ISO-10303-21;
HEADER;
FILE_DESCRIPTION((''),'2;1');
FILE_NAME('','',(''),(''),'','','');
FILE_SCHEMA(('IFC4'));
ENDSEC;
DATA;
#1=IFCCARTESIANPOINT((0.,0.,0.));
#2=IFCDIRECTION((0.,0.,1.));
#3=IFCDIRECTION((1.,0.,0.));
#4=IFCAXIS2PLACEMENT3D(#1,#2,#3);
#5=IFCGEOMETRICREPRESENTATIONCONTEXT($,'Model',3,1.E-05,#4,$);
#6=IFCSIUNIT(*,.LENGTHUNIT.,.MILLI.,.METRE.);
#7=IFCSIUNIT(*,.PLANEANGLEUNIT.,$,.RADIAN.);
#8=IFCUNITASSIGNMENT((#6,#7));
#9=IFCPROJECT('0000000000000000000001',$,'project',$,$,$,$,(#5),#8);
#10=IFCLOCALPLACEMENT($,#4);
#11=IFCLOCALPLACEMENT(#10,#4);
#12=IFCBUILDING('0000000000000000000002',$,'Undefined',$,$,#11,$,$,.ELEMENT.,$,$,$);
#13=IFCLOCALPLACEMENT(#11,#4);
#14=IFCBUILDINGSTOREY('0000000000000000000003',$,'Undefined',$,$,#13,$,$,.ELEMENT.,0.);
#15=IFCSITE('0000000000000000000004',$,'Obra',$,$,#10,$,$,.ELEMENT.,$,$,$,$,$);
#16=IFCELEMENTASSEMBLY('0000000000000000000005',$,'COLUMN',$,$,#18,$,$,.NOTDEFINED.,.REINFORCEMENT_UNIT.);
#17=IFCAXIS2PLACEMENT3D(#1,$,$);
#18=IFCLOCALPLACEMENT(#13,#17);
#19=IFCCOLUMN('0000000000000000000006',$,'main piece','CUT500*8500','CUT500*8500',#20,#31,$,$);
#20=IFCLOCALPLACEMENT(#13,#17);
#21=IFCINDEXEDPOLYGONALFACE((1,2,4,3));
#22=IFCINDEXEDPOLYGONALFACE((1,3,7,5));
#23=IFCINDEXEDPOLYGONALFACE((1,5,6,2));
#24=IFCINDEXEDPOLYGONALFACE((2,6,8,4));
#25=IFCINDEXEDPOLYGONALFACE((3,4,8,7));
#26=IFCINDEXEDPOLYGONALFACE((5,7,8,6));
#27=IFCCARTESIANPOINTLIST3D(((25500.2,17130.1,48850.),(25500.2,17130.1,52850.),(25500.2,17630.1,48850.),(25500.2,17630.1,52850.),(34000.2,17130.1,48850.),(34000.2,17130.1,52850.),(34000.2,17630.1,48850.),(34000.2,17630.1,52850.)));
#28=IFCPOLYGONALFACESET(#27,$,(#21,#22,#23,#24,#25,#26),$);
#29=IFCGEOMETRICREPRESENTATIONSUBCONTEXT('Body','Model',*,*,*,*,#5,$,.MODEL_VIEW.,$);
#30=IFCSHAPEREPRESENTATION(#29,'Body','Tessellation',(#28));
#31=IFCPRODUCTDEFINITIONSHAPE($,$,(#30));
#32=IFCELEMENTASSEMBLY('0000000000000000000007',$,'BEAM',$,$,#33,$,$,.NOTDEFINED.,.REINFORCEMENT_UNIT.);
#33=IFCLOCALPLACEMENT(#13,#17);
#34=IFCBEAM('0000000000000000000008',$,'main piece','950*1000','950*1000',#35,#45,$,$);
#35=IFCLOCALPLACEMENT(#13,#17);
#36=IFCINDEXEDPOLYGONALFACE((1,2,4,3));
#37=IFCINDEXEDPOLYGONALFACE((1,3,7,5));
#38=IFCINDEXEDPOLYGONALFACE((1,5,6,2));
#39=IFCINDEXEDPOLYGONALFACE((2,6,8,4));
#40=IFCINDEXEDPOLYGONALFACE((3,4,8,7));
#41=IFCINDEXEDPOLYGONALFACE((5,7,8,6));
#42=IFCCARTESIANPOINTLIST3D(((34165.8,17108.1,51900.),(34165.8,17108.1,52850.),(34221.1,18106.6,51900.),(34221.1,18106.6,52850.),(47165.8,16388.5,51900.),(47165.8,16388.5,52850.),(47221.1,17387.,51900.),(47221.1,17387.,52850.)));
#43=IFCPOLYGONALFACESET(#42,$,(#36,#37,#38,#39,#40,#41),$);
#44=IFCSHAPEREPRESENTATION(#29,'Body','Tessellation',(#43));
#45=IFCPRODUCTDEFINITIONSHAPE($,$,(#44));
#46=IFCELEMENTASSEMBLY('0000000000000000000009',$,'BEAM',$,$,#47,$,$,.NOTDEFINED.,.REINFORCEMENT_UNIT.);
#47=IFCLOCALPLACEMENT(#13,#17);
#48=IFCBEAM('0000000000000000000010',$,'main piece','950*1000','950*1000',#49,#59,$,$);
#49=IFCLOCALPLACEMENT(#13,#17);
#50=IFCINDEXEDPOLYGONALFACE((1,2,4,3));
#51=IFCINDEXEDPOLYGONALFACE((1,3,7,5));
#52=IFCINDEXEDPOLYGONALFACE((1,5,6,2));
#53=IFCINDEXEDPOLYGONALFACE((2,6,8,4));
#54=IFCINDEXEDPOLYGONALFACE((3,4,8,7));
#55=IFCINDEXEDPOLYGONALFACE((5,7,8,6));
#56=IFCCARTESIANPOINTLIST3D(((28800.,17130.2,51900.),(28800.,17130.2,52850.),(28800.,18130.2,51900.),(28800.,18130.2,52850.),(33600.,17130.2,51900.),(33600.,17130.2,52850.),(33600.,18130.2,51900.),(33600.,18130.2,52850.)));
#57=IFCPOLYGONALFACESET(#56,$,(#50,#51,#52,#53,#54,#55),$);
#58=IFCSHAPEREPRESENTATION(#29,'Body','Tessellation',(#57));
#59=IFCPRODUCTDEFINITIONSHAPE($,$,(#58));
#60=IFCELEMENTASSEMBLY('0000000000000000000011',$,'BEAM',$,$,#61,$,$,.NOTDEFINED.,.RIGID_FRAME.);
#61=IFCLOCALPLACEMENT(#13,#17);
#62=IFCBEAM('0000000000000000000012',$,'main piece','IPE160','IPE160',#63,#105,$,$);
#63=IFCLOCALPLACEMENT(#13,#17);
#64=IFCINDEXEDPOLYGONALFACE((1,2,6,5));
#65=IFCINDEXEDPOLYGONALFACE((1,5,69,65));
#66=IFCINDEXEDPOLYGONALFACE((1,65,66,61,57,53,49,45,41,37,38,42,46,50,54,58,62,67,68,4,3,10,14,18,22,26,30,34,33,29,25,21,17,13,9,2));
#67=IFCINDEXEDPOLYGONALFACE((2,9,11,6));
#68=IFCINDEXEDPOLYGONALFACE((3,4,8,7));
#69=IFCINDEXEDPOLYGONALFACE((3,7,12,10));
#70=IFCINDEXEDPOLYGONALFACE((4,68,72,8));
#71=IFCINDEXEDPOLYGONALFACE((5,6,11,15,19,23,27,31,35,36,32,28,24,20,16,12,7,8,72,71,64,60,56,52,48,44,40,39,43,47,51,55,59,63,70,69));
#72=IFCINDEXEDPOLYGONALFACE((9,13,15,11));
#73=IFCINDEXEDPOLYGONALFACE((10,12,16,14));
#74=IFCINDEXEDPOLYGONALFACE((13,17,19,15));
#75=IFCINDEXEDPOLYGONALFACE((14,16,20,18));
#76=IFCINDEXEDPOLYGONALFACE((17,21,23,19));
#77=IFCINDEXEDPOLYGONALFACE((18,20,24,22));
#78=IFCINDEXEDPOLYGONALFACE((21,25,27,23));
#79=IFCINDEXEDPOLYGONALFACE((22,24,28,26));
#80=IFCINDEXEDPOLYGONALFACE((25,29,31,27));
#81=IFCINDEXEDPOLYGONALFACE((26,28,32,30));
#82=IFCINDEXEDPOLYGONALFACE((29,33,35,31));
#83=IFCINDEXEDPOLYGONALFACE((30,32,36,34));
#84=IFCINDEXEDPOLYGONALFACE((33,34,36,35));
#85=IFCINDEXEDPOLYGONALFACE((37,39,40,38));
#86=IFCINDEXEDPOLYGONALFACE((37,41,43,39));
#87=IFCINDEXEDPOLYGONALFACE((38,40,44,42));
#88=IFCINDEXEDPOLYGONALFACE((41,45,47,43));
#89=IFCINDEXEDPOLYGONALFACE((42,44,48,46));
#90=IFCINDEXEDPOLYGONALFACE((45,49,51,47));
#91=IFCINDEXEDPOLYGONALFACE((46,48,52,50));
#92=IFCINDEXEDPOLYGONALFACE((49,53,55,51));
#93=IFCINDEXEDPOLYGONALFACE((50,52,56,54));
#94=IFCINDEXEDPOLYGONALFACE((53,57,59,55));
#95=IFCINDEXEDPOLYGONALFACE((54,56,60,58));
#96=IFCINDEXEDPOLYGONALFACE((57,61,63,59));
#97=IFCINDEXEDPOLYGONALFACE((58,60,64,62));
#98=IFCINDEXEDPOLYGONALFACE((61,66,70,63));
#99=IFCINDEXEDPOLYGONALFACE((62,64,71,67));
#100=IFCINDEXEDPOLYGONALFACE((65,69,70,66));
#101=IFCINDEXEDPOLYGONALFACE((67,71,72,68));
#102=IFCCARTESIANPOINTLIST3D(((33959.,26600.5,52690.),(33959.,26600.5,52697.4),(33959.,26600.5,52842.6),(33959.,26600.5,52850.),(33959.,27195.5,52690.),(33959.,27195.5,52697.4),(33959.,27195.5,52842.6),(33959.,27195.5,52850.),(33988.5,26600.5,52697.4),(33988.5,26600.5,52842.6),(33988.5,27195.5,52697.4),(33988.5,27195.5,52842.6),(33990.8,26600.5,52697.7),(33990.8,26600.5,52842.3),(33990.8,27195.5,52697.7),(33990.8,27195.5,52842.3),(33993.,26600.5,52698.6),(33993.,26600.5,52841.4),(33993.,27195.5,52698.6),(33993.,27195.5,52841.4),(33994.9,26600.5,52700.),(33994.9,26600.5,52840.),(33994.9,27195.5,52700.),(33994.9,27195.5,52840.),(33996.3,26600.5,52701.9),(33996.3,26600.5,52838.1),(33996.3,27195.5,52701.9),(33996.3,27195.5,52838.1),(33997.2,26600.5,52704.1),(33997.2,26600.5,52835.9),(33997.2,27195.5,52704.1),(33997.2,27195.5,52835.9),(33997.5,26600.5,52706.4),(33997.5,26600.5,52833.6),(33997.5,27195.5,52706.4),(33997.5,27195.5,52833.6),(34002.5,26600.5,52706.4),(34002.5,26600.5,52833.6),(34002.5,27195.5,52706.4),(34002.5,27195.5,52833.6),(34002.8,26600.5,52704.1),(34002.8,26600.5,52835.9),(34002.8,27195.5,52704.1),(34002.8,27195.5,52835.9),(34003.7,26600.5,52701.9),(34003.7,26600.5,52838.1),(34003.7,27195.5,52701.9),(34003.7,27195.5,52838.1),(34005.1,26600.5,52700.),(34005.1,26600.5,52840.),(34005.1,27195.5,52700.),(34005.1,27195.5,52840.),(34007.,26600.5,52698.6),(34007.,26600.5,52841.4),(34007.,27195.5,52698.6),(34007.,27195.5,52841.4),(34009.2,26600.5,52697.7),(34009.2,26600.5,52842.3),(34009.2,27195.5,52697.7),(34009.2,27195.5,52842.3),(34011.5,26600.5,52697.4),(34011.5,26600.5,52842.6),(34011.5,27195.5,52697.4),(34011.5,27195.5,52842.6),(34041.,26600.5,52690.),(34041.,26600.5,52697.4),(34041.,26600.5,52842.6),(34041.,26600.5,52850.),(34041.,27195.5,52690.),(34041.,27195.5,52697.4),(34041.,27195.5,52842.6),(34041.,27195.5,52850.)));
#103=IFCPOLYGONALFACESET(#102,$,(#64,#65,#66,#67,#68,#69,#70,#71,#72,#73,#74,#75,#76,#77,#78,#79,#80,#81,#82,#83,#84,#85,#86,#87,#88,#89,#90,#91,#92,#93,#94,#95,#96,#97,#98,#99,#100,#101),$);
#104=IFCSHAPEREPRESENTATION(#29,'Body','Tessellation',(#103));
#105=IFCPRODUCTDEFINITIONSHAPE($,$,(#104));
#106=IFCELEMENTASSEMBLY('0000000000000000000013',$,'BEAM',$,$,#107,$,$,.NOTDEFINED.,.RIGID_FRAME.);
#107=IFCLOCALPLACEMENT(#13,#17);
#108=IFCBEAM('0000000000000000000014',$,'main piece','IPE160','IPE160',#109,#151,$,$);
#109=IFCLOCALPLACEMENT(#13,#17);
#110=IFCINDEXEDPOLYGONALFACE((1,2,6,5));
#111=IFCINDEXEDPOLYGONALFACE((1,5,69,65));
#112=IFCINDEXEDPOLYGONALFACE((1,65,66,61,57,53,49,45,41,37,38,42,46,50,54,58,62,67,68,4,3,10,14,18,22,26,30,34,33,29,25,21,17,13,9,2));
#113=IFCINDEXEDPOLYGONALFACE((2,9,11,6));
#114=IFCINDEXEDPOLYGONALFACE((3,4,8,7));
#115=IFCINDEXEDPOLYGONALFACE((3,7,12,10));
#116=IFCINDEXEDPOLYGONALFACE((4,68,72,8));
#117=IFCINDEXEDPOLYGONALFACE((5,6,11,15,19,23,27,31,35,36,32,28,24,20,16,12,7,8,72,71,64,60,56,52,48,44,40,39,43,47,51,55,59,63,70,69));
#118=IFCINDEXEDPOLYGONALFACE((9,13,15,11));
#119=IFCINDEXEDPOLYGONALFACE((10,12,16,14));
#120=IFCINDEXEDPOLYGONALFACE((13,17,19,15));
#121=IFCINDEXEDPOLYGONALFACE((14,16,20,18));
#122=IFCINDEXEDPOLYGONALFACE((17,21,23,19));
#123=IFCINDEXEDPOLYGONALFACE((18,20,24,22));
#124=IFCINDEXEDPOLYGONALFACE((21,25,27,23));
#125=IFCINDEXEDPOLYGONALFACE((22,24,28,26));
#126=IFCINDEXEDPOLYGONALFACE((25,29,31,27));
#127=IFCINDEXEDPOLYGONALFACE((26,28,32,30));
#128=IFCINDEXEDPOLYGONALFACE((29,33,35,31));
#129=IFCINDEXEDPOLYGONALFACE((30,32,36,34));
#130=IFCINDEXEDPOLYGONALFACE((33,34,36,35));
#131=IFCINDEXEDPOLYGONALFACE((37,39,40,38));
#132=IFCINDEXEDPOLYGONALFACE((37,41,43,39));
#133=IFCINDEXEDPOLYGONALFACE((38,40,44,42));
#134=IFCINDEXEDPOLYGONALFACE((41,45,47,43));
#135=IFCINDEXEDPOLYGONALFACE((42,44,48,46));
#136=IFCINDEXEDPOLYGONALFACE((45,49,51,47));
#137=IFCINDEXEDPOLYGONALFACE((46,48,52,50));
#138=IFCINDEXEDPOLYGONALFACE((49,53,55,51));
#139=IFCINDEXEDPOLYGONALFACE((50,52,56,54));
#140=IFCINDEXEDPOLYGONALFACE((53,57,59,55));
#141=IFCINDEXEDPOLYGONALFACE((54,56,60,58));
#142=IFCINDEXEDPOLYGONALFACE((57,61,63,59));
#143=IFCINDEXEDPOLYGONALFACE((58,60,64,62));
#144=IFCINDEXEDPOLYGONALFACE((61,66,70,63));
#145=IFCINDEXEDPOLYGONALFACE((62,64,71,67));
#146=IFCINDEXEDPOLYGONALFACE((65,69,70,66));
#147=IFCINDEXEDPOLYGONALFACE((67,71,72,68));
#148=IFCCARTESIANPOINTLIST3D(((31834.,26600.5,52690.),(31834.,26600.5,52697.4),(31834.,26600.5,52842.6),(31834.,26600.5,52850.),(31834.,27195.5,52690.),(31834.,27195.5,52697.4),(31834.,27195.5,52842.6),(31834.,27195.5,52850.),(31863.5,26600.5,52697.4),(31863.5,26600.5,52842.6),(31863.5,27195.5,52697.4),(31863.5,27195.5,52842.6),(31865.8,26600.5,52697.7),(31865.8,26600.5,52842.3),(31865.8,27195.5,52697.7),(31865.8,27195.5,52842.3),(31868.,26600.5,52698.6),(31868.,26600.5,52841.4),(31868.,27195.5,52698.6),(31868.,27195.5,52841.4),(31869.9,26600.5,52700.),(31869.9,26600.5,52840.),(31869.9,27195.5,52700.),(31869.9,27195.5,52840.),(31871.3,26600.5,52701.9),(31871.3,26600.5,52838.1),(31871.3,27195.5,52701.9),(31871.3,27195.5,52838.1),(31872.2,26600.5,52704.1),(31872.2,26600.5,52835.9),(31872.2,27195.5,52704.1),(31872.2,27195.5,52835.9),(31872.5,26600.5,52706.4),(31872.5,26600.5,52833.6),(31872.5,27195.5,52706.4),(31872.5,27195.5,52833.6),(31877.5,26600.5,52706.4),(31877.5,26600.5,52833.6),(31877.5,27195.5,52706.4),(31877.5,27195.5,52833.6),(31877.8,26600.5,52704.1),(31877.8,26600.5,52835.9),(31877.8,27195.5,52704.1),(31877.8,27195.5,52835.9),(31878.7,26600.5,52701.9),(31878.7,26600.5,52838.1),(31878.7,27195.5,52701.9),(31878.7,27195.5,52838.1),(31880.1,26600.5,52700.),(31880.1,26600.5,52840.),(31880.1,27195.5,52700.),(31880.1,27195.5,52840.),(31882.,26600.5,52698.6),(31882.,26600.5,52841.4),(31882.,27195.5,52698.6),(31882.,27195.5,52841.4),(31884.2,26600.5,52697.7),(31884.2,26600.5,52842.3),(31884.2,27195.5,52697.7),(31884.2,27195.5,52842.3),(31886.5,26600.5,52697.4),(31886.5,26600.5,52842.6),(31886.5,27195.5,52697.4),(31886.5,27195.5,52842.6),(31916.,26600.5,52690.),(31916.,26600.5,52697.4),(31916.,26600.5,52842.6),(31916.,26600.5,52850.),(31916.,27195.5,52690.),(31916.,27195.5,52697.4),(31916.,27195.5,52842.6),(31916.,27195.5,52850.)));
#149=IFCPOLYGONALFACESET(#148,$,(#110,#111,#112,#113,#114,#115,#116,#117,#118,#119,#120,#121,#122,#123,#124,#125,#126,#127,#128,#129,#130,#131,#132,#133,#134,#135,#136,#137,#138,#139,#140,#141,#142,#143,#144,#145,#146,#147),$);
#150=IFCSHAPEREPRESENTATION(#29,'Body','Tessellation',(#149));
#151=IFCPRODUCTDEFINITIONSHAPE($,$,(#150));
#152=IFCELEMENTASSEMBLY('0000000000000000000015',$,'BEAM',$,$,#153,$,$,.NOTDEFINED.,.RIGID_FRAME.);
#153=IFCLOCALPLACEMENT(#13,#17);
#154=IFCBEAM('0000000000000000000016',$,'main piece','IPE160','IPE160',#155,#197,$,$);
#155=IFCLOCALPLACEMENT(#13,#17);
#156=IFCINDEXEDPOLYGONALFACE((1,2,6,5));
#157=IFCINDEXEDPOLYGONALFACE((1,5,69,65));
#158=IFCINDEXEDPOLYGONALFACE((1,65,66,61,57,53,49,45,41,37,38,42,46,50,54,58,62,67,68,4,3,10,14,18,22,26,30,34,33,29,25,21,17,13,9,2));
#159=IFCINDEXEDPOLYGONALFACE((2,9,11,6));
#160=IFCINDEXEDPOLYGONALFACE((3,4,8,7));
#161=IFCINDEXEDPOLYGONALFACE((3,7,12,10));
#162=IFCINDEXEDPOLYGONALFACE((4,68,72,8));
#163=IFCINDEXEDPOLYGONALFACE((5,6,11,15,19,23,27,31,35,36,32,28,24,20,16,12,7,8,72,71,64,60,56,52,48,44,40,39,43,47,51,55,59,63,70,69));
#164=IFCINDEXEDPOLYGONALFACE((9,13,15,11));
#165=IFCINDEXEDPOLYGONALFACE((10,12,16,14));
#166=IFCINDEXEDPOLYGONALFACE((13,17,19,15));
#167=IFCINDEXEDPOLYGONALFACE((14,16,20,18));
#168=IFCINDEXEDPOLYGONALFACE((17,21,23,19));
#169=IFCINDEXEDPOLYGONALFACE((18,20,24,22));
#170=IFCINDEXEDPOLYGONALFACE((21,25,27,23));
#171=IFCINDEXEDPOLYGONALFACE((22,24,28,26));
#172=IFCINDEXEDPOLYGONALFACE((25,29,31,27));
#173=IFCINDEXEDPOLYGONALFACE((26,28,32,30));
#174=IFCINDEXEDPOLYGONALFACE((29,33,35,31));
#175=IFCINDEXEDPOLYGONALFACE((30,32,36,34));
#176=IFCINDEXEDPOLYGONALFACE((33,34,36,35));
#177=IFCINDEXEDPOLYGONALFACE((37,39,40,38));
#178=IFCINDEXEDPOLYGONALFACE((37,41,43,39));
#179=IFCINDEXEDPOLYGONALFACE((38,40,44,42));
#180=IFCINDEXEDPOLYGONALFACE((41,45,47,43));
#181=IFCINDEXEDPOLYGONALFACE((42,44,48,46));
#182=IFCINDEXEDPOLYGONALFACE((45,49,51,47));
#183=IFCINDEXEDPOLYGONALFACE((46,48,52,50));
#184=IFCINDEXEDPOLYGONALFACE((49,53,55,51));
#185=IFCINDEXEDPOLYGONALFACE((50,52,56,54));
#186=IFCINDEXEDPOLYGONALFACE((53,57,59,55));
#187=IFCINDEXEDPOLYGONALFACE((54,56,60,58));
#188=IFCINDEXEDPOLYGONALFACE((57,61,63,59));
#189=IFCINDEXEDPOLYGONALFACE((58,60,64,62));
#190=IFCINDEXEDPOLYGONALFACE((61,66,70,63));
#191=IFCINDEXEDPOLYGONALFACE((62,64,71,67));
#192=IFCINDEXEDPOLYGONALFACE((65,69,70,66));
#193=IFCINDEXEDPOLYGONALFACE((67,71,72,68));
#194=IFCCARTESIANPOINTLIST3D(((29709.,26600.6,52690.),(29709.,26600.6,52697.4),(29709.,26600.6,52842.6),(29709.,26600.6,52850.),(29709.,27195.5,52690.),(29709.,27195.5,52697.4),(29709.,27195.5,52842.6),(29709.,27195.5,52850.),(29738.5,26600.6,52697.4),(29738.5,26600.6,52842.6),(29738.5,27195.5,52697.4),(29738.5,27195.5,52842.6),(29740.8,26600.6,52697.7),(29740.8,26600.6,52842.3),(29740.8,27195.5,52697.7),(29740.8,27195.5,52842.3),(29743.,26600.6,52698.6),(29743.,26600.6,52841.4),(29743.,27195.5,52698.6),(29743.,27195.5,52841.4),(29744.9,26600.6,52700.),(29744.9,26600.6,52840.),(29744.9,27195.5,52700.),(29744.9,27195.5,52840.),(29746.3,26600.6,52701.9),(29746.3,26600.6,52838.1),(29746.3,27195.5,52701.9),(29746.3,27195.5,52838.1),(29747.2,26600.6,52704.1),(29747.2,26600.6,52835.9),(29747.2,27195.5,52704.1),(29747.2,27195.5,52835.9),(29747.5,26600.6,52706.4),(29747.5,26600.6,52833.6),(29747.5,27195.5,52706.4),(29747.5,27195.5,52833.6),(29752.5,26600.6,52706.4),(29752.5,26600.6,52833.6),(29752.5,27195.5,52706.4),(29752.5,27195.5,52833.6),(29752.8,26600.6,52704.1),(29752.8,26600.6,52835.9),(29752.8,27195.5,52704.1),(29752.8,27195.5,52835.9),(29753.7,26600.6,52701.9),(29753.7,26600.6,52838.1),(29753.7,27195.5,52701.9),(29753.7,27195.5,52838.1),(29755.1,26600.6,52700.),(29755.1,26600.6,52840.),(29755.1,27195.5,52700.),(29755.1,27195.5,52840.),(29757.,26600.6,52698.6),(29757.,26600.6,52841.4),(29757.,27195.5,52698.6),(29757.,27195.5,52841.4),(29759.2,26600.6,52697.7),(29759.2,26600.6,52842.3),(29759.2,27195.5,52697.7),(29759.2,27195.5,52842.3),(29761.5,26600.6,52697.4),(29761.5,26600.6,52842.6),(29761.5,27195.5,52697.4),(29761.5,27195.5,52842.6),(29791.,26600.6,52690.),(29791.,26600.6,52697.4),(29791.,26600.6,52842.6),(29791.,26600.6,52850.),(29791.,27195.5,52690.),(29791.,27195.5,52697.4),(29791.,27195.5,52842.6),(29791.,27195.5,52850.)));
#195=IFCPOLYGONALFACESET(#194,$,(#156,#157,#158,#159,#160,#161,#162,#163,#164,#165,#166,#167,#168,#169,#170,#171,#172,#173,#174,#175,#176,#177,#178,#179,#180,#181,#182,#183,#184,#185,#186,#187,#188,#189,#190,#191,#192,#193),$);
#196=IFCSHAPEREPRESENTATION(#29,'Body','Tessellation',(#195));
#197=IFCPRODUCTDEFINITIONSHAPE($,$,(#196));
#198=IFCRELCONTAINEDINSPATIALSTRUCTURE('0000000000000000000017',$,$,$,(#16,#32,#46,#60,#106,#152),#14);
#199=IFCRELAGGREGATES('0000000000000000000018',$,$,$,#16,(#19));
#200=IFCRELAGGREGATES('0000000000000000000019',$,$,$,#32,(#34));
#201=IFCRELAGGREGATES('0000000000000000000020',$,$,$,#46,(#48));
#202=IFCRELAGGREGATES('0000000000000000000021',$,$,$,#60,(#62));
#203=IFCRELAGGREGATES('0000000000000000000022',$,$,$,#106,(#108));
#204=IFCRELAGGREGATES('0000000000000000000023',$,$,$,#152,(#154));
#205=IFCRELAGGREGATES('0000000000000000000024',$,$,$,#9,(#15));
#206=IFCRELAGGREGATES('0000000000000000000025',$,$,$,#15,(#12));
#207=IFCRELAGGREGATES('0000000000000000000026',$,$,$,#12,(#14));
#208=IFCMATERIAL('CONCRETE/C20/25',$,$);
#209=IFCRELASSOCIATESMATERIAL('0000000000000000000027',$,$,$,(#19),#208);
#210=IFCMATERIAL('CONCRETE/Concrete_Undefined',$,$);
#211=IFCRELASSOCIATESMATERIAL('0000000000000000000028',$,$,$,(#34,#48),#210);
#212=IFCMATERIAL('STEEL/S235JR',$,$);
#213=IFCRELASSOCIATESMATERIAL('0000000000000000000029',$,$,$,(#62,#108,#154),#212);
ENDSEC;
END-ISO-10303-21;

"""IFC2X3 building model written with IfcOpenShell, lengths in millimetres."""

from ifc_helpers import new_model, si_unit, frame, origin_with_axes, origin_2d_with_axis, place, context, subcontext, project, spatial, rectangle, i_section, extrude, material, element, aggregate, save


model = new_model("IFC2X3")

# Units and contexts
model_context = context("Model", 3, precision=1e-05, world=origin_with_axes())
body_context = subcontext(model_context, "Body", "Model", "MODEL_VIEW")
ifc_project = project(units=[si_unit("LENGTHUNIT", "METRE", prefix="MILLI"), si_unit("PLANEANGLEUNIT", "RADIAN")], contexts=[model_context])

# Site, building, storey
site_placement = place(None, origin_with_axes())
site = spatial("IfcSite", under=ifc_project, at=site_placement, Name="Obra", CompositionType="ELEMENT")
building_placement = place(site_placement, origin_with_axes())
building = spatial("IfcBuilding", under=site, at=building_placement, Name="Undefined", CompositionType="ELEMENT")
storey_placement = place(building_placement, origin_with_axes())
storey = spatial("IfcBuildingStorey", under=building, at=storey_placement, Name="Undefined", CompositionType="ELEMENT", Elevation=0.0)

# Element assembly, column
ifc_material_1 = material(Name="STEEL/S235JR")
ifc_material_2 = material(Name="CONCRETE/C20/25")
assembly_1_placement = place(storey_placement, origin_with_axes())
assembly_1 = element("IfcElementAssembly", 1, at=assembly_1_placement, inside=storey, Name="COLUMN", AssemblyPlace="NOTDEFINED", PredefinedType="REINFORCEMENT_UNIT")
column_1_placement = place(assembly_1_placement, frame((29750.2, 17380.1, 48850.0), z_axis=(0.0, 0.0, 1.0), x_axis=(-1.0, 0.0, 0.0)))
column_1 = element("IfcColumn", 2, at=column_1_placement, material=ifc_material_2, Name="main piece", Description="CUT500*8500", ObjectType="CUT500*8500", context=body_context, shape_type="SweptSolid", body=[
    extrude(rectangle(XDim=500.0, YDim=8500.0, at=origin_2d_with_axis()), frame((0.0, 0.0, 4000.0), z_axis=(0.0, 0.0, -1.0), x_axis=(0.0, 1.0, 0.0)), (0.0, 0.0, 1.0), 4000.0),
])
aggregate(assembly_1, [column_1])

# Element assemblies, beams
assembly_2_placement = place(storey_placement, origin_with_axes())
assembly_2 = element("IfcElementAssembly", 3, at=assembly_2_placement, inside=storey, Name="BEAM", AssemblyPlace="NOTDEFINED", PredefinedType="REINFORCEMENT_UNIT")
ifc_material_3 = material(Name="CONCRETE/Concrete_Undefined")
beam_1_placement = place(assembly_2_placement, frame((34193.5, 17607.3, 52375.0), z_axis=(0.0, 0.0, 1.0), x_axis=(0.998472, -0.055268, 0.0)))
beam_1 = element("IfcBeam", 4, at=beam_1_placement, material=ifc_material_3, Name="main piece", Description="950*1000", ObjectType="950*1000", context=body_context, shape_type="SweptSolid", body=[
    extrude(rectangle(XDim=1000.0, YDim=950.0, at=origin_2d_with_axis()), frame((13019.9, 0.0, 0.0), z_axis=(-1.0, 0.0, 0.0), x_axis=(0.0, -1.0, 0.0)), (0.0, 0.0, 1.0), 13019.9),
])
aggregate(assembly_2, [beam_1])
assembly_3_placement = place(storey_placement, origin_with_axes())
assembly_3 = element("IfcElementAssembly", 5, at=assembly_3_placement, inside=storey, Name="BEAM", AssemblyPlace="NOTDEFINED", PredefinedType="REINFORCEMENT_UNIT")
beam_2_placement = place(assembly_3_placement, frame((28800.0, 17630.2, 52375.0), z_axis=(0.0, 0.0, 1.0), x_axis=(1.0, 0.000002, 0.0)))
beam_2 = element("IfcBeam", 6, at=beam_2_placement, material=ifc_material_3, Name="main piece", Description="950*1000", ObjectType="950*1000", context=body_context, shape_type="SweptSolid", body=[
    extrude(rectangle(XDim=1000.0, YDim=950.0, at=origin_2d_with_axis()), frame((4800.0, 0.0, 0.0), z_axis=(-1.0, 0.0, 0.0), x_axis=(0.0, -1.0, 0.0)), (0.0, 0.0, 1.0), 4800.0),
])
aggregate(assembly_3, [beam_2])
assembly_4_placement = place(storey_placement, origin_with_axes())
assembly_4 = element("IfcElementAssembly", 7, at=assembly_4_placement, inside=storey, Name="BEAM", AssemblyPlace="NOTDEFINED", PredefinedType="RIGID_FRAME")
beam_3_placement = place(assembly_4_placement, frame((34000.0, 26600.5, 52770.0), z_axis=(0.0, 0.0, 1.0), x_axis=(0.0, 1.0, 0.0)))
beam_3 = element("IfcBeam", 8, at=beam_3_placement, material=ifc_material_1, Name="main piece", Description="IPE160", ObjectType="IPE160", context=body_context, shape_type="SweptSolid", body=[
    extrude(i_section(OverallWidth=82.0, OverallDepth=160.0, WebThickness=5.0, FlangeThickness=7.4, FilletRadius=9.0, at=origin_2d_with_axis()), frame((595.1, 0.0, 0.0), z_axis=(-1.0, 0.0, 0.0), x_axis=(0.0, -1.0, 0.0)), (0.0, 0.0, 1.0), 595.0),
])
aggregate(assembly_4, [beam_3])
assembly_5_placement = place(storey_placement, origin_with_axes())
assembly_5 = element("IfcElementAssembly", 9, at=assembly_5_placement, inside=storey, Name="BEAM", AssemblyPlace="NOTDEFINED", PredefinedType="RIGID_FRAME")
beam_4_placement = place(assembly_5_placement, frame((31875.0, 26600.5, 52770.0), z_axis=(0.0, 0.0, 1.0), x_axis=(0.0, 1.0, 0.0)))
beam_4 = element("IfcBeam", 10, at=beam_4_placement, material=ifc_material_1, Name="main piece", Description="IPE160", ObjectType="IPE160", context=body_context, shape_type="SweptSolid", body=[
    extrude(i_section(OverallWidth=82.0, OverallDepth=160.0, WebThickness=5.0, FlangeThickness=7.4, FilletRadius=9.0, at=origin_2d_with_axis()), frame((595.0, 0.0, 0.0), z_axis=(-1.0, 0.0, 0.0), x_axis=(0.0, -1.0, 0.0)), (0.0, 0.0, 1.0), 595.0),
])
aggregate(assembly_5, [beam_4])
assembly_6_placement = place(storey_placement, origin_with_axes())
assembly_6 = element("IfcElementAssembly", 11, at=assembly_6_placement, inside=storey, Name="BEAM", AssemblyPlace="NOTDEFINED", PredefinedType="RIGID_FRAME")
beam_5_placement = place(assembly_6_placement, frame((29750.0, 26600.6, 52770.0), z_axis=(0.0, 0.0, 1.0), x_axis=(0.0, 1.0, 0.0)))
beam_5 = element("IfcBeam", 12, at=beam_5_placement, material=ifc_material_1, Name="main piece", Description="IPE160", ObjectType="IPE160", context=body_context, shape_type="SweptSolid", body=[
    extrude(i_section(OverallWidth=82.0, OverallDepth=160.0, WebThickness=5.0, FlangeThickness=7.4, FilletRadius=9.0, at=origin_2d_with_axis()), frame((594.9, 0.0, 0.0), z_axis=(-1.0, 0.0, 0.0), x_axis=(0.0, -1.0, 0.0)), (0.0, 0.0, 1.0), 594.9),
])
aggregate(assembly_6, [beam_5])

save(model, "model.ifc")
